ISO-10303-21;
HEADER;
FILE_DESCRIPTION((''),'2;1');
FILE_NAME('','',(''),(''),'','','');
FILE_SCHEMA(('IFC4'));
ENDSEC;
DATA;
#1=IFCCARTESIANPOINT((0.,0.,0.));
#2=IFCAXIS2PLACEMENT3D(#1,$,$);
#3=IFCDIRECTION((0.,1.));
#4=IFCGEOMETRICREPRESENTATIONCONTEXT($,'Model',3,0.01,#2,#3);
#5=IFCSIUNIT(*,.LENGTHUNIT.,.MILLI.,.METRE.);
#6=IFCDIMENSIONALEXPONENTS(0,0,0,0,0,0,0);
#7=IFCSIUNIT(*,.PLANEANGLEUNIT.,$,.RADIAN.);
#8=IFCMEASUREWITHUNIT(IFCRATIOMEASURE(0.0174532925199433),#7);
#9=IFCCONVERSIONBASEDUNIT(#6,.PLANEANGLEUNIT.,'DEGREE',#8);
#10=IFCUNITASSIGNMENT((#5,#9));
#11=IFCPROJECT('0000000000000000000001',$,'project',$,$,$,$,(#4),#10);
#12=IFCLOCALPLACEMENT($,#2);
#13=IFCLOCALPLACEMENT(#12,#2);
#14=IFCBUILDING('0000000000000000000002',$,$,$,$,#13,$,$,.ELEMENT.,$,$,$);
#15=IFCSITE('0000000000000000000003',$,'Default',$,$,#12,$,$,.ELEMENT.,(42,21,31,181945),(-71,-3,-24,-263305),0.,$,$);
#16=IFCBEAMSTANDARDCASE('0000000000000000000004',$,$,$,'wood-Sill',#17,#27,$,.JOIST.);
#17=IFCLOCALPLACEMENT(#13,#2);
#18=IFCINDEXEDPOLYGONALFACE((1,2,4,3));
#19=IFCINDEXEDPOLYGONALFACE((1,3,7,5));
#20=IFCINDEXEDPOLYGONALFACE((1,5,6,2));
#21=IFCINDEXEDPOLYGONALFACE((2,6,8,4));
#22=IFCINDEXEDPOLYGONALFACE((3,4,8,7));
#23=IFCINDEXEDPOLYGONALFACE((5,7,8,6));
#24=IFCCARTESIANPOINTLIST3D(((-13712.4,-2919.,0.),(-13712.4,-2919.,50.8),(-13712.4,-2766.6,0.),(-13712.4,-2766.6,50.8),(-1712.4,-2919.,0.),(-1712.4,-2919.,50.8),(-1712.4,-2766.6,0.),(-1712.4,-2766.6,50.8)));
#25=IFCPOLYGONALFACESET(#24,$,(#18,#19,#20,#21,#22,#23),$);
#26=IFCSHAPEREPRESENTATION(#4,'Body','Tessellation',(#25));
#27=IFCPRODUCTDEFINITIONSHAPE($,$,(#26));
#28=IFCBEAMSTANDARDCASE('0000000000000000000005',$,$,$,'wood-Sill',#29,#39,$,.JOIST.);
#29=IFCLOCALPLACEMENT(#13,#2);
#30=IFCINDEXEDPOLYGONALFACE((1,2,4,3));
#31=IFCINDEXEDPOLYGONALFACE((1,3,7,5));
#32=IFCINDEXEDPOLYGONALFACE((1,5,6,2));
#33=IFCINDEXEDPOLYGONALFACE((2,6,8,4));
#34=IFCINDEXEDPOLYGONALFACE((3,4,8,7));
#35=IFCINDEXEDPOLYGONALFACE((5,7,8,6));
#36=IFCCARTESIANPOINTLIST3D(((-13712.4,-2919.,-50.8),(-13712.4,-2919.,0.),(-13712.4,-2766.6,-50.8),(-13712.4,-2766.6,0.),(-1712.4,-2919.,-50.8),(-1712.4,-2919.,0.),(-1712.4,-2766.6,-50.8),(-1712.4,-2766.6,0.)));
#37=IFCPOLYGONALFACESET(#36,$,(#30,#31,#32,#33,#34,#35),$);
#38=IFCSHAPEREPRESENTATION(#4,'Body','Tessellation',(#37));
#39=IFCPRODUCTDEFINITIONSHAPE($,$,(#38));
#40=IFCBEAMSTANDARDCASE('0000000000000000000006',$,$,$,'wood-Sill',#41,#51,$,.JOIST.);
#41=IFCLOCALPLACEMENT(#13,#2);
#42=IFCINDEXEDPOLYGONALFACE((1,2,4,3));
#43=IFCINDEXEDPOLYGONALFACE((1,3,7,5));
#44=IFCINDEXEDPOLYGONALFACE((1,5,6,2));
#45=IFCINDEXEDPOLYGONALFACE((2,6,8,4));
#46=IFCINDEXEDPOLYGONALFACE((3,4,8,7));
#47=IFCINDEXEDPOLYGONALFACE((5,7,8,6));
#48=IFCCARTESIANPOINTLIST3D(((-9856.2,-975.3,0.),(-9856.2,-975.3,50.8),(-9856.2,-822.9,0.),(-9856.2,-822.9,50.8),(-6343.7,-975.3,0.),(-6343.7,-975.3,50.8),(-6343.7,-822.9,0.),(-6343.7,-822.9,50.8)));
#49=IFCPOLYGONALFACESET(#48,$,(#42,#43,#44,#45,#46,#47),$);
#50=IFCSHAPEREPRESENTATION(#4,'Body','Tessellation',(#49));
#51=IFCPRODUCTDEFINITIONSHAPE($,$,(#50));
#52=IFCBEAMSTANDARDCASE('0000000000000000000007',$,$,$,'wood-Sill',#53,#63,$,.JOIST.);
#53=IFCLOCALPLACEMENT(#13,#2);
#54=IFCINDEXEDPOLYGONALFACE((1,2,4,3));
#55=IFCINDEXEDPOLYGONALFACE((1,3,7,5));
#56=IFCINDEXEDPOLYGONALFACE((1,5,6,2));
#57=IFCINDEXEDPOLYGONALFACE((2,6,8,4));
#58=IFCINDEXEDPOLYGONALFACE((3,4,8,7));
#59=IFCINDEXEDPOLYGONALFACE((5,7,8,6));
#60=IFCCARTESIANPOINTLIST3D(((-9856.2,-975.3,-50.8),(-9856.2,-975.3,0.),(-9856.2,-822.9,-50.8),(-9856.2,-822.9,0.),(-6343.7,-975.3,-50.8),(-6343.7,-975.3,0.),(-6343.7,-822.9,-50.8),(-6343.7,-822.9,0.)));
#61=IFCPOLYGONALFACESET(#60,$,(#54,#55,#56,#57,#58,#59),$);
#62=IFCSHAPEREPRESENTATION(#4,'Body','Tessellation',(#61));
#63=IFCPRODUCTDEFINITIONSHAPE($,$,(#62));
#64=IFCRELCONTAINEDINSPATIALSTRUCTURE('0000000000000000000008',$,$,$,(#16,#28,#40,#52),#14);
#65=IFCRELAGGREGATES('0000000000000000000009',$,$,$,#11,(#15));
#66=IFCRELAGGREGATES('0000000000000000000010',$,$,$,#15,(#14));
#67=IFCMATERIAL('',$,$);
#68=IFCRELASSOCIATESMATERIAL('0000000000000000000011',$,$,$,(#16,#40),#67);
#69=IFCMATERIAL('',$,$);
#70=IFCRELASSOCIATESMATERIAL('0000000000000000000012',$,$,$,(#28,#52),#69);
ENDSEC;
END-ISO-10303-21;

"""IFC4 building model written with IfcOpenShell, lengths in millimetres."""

from ifc_helpers import new_model, entity, si_unit, converted_unit, direction, frame, origin, place, context, project, spatial, rectangle, extrude, material, element, save


model = new_model("IFC4")

# Units and contexts
model_context = context("Model", 3, precision=0.01, world=origin(), true_north=direction((0.0, 1.0)))
ifc_project = project(units=[si_unit("LENGTHUNIT", "METRE", prefix="MILLI"), converted_unit("PLANEANGLEUNIT", "DEGREE", entity("IfcRatioMeasure", 0.0174532925199433), si_unit("PLANEANGLEUNIT", "RADIAN"), dimensions=[0, 0, 0, 0, 0, 0, 0])], contexts=[model_context])

# Site, building
site_placement = place(None, origin())
site = spatial("IfcSite", under=ifc_project, at=site_placement, Name="Default", CompositionType="ELEMENT", RefLatitude=(42, 21, 31, 181945), RefLongitude=(-71, -3, -24, -263305), RefElevation=0.0)
building_placement = place(site_placement, origin())
building = spatial("IfcBuilding", under=site, at=building_placement, CompositionType="ELEMENT")

# Shared definitions
placement_1 = place(building_placement, origin())
placement_2 = place(placement_1, frame((-13712.4, -2842.8, 0.0)))

# Beams
ifc_material_1 = material(Name="")
beam_1_placement = place(placement_2, frame((6000.0, 0.0, 0.0)))
element("IfcBeamStandardCase", 1, at=beam_1_placement, inside=building, material=ifc_material_1, ObjectType="wood-Sill", PredefinedType="JOIST", context=model_context, shape_type="SweptSolid", body=[
    extrude(rectangle(XDim=12000.0, YDim=152.4), origin(), (0.0, 0.0, 1.0), 50.8),
])
ifc_material_2 = material(Name="")
beam_2_placement = place(placement_2, frame((6000.0, 0.0, -50.8)))
element("IfcBeamStandardCase", 2, at=beam_2_placement, inside=building, material=ifc_material_2, ObjectType="wood-Sill", PredefinedType="JOIST", context=model_context, shape_type="SweptSolid", body=[
    extrude(rectangle(XDim=12000.0, YDim=152.4), origin(), (0.0, 0.0, 1.0), 50.8),
])
placement_3 = place(placement_1, frame((-8099.9, 857.2, 0.0), z_axis=(0.0, 0.0, 1.0), x_axis=(0.0, -1.0, 0.0)))
beam_3_placement = place(placement_3, frame((1756.2, 0.0, 0.0), z_axis=(0.0, 0.0, 1.0), x_axis=(0.0, -1.0, 0.0)))
element("IfcBeamStandardCase", 3, at=beam_3_placement, inside=building, material=ifc_material_1, ObjectType="wood-Sill", PredefinedType="JOIST", context=model_context, shape_type="SweptSolid", body=[
    extrude(rectangle(XDim=3512.5, YDim=152.4), origin(), (0.0, 0.0, 1.0), 50.8),
])
beam_4_placement = place(placement_3, frame((1756.2, 0.0, -50.8), z_axis=(0.0, 0.0, 1.0), x_axis=(0.0, -1.0, 0.0)))
element("IfcBeamStandardCase", 4, at=beam_4_placement, inside=building, material=ifc_material_2, ObjectType="wood-Sill", PredefinedType="JOIST", context=model_context, shape_type="SweptSolid", body=[
    extrude(rectangle(XDim=3512.5, YDim=152.4), origin(), (0.0, 0.0, 1.0), 50.8),
])

save(model, "model.ifc")
